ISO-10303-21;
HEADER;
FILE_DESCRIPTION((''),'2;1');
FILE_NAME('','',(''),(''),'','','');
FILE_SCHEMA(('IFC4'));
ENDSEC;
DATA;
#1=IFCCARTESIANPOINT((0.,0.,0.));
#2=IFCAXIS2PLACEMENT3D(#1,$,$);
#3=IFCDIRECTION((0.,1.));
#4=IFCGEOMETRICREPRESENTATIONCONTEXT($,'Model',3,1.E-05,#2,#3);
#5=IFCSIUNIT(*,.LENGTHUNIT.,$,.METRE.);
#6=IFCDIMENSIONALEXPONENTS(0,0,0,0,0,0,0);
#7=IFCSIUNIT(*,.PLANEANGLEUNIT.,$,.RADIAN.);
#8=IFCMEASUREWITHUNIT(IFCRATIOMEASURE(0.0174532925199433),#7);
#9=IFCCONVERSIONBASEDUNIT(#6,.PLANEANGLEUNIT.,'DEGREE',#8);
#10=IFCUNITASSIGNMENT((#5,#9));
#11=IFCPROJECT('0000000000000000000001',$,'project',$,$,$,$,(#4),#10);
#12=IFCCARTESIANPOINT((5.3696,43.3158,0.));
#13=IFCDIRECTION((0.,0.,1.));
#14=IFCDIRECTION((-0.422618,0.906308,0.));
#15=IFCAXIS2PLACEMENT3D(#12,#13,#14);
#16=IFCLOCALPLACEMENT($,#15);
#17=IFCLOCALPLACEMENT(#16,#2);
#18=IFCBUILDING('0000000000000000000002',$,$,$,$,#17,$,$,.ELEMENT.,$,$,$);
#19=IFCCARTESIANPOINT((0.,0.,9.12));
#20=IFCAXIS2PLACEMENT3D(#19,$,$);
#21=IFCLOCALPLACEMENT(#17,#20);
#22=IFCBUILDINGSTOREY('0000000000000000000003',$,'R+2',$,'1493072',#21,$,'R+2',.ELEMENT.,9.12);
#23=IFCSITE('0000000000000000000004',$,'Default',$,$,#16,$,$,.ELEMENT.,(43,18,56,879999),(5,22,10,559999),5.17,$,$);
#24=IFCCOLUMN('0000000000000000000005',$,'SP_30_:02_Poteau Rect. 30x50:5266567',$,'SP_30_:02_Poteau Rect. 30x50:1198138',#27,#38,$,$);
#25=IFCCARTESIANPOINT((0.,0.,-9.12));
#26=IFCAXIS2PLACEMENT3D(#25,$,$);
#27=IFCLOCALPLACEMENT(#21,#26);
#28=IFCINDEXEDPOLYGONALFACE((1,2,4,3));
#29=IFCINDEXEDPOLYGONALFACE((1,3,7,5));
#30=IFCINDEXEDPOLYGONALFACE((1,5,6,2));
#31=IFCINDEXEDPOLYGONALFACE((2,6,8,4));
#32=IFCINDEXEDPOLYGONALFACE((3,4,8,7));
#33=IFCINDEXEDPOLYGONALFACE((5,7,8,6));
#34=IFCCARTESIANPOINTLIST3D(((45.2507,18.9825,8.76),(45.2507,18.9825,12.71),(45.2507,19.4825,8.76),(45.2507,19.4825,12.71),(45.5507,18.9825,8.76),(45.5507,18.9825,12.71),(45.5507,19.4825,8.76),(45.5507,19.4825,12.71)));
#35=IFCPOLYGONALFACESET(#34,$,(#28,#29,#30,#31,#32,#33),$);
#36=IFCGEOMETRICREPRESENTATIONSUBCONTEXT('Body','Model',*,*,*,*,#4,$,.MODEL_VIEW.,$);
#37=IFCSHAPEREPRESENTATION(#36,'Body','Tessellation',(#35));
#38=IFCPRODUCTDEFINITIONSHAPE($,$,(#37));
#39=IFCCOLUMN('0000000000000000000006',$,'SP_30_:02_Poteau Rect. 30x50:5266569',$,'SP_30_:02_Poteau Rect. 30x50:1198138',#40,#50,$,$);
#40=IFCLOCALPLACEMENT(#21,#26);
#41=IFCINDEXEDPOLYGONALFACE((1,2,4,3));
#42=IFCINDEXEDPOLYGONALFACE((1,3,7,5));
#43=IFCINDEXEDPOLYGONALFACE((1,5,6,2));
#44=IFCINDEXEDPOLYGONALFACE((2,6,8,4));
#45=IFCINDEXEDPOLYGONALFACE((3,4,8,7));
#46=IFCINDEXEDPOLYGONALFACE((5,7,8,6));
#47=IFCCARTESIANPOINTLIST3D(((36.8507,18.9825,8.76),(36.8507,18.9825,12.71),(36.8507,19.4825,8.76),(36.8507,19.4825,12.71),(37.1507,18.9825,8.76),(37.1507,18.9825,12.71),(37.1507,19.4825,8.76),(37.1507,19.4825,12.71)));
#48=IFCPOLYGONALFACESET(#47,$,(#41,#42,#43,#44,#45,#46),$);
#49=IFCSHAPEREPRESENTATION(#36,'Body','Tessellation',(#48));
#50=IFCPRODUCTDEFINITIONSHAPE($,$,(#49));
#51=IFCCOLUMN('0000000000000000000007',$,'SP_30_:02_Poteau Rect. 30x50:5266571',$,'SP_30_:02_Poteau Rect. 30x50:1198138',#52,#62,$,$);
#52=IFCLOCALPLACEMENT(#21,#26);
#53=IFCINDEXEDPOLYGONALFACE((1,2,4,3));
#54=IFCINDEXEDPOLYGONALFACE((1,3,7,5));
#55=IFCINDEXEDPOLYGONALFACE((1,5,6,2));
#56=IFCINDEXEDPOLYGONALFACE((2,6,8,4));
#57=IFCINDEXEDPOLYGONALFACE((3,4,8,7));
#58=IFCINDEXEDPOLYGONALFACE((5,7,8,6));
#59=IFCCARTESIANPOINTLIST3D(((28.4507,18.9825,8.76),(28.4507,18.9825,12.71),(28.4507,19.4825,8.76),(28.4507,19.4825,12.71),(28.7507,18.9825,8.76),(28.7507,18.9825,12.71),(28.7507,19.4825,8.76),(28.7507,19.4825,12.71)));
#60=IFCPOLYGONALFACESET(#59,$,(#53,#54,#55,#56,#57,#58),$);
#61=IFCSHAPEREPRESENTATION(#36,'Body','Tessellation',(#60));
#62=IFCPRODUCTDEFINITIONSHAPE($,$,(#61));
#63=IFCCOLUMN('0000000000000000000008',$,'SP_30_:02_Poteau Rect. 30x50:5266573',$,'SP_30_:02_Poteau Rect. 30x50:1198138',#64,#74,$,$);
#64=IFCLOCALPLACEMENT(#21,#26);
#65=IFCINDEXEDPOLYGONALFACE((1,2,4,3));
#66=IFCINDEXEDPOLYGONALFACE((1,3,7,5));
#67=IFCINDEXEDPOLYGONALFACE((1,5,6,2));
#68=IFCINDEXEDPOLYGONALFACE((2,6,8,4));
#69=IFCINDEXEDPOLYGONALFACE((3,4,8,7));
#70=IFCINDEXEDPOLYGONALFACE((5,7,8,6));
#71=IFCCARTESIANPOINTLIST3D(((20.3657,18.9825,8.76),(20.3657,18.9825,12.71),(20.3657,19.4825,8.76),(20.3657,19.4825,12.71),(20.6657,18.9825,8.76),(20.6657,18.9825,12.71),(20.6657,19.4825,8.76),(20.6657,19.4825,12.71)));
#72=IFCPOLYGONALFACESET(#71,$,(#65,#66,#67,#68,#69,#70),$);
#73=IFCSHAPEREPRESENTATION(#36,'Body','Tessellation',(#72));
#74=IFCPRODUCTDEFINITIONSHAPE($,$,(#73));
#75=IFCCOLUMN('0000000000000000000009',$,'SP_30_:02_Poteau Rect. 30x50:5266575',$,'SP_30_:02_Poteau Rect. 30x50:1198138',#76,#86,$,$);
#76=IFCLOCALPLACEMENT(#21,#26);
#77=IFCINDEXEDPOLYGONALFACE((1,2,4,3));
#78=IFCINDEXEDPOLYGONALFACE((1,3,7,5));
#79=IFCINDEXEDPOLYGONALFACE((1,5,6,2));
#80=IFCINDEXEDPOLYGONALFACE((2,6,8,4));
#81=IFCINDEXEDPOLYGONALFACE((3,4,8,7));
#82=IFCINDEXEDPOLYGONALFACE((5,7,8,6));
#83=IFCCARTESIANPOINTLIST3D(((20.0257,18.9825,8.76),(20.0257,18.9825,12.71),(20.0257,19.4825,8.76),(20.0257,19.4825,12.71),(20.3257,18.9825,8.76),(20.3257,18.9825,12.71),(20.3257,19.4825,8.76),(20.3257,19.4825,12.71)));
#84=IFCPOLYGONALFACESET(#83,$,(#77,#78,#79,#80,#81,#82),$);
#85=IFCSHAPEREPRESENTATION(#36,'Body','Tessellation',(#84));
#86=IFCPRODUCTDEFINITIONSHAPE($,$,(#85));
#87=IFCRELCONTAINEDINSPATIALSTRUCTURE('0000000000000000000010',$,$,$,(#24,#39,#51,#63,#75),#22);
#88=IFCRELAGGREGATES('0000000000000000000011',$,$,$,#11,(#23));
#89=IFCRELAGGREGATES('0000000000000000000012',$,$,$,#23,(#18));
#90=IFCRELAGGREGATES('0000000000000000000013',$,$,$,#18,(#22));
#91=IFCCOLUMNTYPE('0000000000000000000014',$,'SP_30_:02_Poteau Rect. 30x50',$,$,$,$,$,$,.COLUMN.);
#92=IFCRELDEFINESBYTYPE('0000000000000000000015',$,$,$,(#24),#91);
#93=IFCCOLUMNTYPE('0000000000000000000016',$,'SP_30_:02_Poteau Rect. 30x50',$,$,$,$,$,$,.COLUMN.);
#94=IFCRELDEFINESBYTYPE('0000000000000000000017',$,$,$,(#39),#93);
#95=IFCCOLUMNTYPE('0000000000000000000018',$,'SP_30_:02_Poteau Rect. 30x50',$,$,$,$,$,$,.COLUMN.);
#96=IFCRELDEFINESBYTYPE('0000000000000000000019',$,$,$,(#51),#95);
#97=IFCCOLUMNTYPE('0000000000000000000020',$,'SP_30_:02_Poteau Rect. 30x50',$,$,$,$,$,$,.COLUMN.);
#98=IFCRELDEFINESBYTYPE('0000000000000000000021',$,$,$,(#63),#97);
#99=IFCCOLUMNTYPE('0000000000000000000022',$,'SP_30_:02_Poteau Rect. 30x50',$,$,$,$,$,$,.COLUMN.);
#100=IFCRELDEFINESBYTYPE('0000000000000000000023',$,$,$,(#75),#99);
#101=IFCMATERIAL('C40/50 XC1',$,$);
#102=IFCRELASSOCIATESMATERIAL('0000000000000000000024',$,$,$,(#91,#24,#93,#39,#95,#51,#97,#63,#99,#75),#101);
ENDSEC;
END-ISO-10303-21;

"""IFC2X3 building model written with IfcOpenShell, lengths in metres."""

from ifc_helpers import new_model, entity, si_unit, converted_unit, direction, frame, frame_2d, origin, place, context, subcontext, project, spatial, rectangle, extrude, source, transform, mapped, material, type_object, type_shapes, element, save


model = new_model("IFC2X3")

# Units and contexts
model_context = context("Model", 3, precision=1e-05, world=origin(), true_north=direction((0.0, 1.0)))
body_context = subcontext(model_context, "Body", "Model", "MODEL_VIEW")
ifc_project = project(units=[si_unit("LENGTHUNIT", "METRE"), converted_unit("PLANEANGLEUNIT", "DEGREE", entity("IfcRatioMeasure", 0.0174532925199433), si_unit("PLANEANGLEUNIT", "RADIAN"), dimensions=[0, 0, 0, 0, 0, 0, 0])], contexts=[model_context])

# Site, building, storey
site_placement = place(None, frame((5.3696, 43.3158, 0.0), z_axis=(0.0, 0.0, 1.0), x_axis=(-0.422618, 0.906308, 0.0)))
site = spatial("IfcSite", under=ifc_project, at=site_placement, Name="Default", CompositionType="ELEMENT", RefLatitude=(43, 18, 56, 879999), RefLongitude=(5, 22, 10, 559999), RefElevation=5.17)
building_placement = place(site_placement, origin())
building = spatial("IfcBuilding", under=site, at=building_placement, CompositionType="ELEMENT")
storey_placement = place(building_placement, frame((0.0, 0.0, 9.12)))
storey = spatial("IfcBuildingStorey", under=building, at=storey_placement, Name="R+2", ObjectType="1493072", LongName="R+2", CompositionType="ELEMENT", Elevation=9.12)

# Columns
ifc_material_1 = material(Name="C40/50 XC1")
column_type_1 = type_object("IfcColumnType", Name="SP_30_:02_Poteau Rect. 30x50", PredefinedType="COLUMN", material=ifc_material_1)
shared_shape_1 = source(origin(), body_context, "Body", "SweptSolid", [
    extrude(rectangle(XDim=0.3, YDim=0.5, at=frame_2d((0.0, 0.0), x_axis=(1.0, 0.0))), frame((45.4007, 19.2325, 8.76), z_axis=(0.0, 0.0, 1.0), x_axis=(-1.0, 0.0, 0.0)), (0.0, 0.0, 1.0), 3.95),
])
type_shapes(column_type_1, [shared_shape_1])
column_1_placement = place(storey_placement, frame((0.0, 0.0, -9.12)))
element("IfcColumn", 1, at=column_1_placement, inside=storey, type_object=column_type_1, material=ifc_material_1, Name="SP_30_:02_Poteau Rect. 30x50:5266567", ObjectType="SP_30_:02_Poteau Rect. 30x50:1198138", context=body_context, shape_type="MappedRepresentation", body=[
    mapped(shared_shape_1, transform((0.0, 0.0, 0.0), scale=1.0)),
])
column_type_2 = type_object("IfcColumnType", Name="SP_30_:02_Poteau Rect. 30x50", PredefinedType="COLUMN", material=ifc_material_1)
shared_shape_2 = source(origin(), body_context, "Body", "SweptSolid", [
    extrude(rectangle(XDim=0.3, YDim=0.5, at=frame_2d((0.0, 0.0), x_axis=(1.0, 0.0))), frame((37.0007, 19.2325, 8.76), z_axis=(0.0, 0.0, 1.0), x_axis=(-1.0, 0.0, 0.0)), (0.0, 0.0, 1.0), 3.95),
])
type_shapes(column_type_2, [shared_shape_2])
column_2_placement = place(storey_placement, frame((0.0, 0.0, -9.12)))
element("IfcColumn", 2, at=column_2_placement, inside=storey, type_object=column_type_2, material=ifc_material_1, Name="SP_30_:02_Poteau Rect. 30x50:5266569", ObjectType="SP_30_:02_Poteau Rect. 30x50:1198138", context=body_context, shape_type="MappedRepresentation", body=[
    mapped(shared_shape_2, transform((0.0, 0.0, 0.0), scale=1.0)),
])
column_type_3 = type_object("IfcColumnType", Name="SP_30_:02_Poteau Rect. 30x50", PredefinedType="COLUMN", material=ifc_material_1)
shared_shape_3 = source(origin(), body_context, "Body", "SweptSolid", [
    extrude(rectangle(XDim=0.3, YDim=0.5, at=frame_2d((0.0, 0.0), x_axis=(1.0, 0.0))), frame((28.6007, 19.2325, 8.76)), (0.0, 0.0, 1.0), 3.95),
])
type_shapes(column_type_3, [shared_shape_3])
column_3_placement = place(storey_placement, frame((0.0, 0.0, -9.12)))
element("IfcColumn", 3, at=column_3_placement, inside=storey, type_object=column_type_3, material=ifc_material_1, Name="SP_30_:02_Poteau Rect. 30x50:5266571", ObjectType="SP_30_:02_Poteau Rect. 30x50:1198138", context=body_context, shape_type="MappedRepresentation", body=[
    mapped(shared_shape_3, transform((0.0, 0.0, 0.0), scale=1.0)),
])
column_type_4 = type_object("IfcColumnType", Name="SP_30_:02_Poteau Rect. 30x50", PredefinedType="COLUMN", material=ifc_material_1)
shared_shape_4 = source(origin(), body_context, "Body", "SweptSolid", [
    extrude(rectangle(XDim=0.3, YDim=0.5, at=frame_2d((0.0, 0.0), x_axis=(1.0, 0.0))), frame((20.5157, 19.2325, 8.76), z_axis=(0.0, 0.0, 1.0), x_axis=(-1.0, 0.0, 0.0)), (0.0, 0.0, 1.0), 3.95),
])
type_shapes(column_type_4, [shared_shape_4])
column_4_placement = place(storey_placement, frame((0.0, 0.0, -9.12)))
element("IfcColumn", 4, at=column_4_placement, inside=storey, type_object=column_type_4, material=ifc_material_1, Name="SP_30_:02_Poteau Rect. 30x50:5266573", ObjectType="SP_30_:02_Poteau Rect. 30x50:1198138", context=body_context, shape_type="MappedRepresentation", body=[
    mapped(shared_shape_4, transform((0.0, 0.0, 0.0), scale=1.0)),
])
column_type_5 = type_object("IfcColumnType", Name="SP_30_:02_Poteau Rect. 30x50", PredefinedType="COLUMN", material=ifc_material_1)
shared_shape_5 = source(origin(), body_context, "Body", "SweptSolid", [
    extrude(rectangle(XDim=0.3, YDim=0.5, at=frame_2d((0.0, 0.0), x_axis=(1.0, 0.0))), frame((20.1757, 19.2325, 8.76), z_axis=(0.0, 0.0, 1.0), x_axis=(-1.0, 0.0, 0.0)), (0.0, 0.0, 1.0), 3.95),
])
type_shapes(column_type_5, [shared_shape_5])
column_5_placement = place(storey_placement, frame((0.0, 0.0, -9.12)))
element("IfcColumn", 5, at=column_5_placement, inside=storey, type_object=column_type_5, material=ifc_material_1, Name="SP_30_:02_Poteau Rect. 30x50:5266575", ObjectType="SP_30_:02_Poteau Rect. 30x50:1198138", context=body_context, shape_type="MappedRepresentation", body=[
    mapped(shared_shape_5, transform((0.0, 0.0, 0.0), scale=1.0)),
])

save(model, "model.ifc")
